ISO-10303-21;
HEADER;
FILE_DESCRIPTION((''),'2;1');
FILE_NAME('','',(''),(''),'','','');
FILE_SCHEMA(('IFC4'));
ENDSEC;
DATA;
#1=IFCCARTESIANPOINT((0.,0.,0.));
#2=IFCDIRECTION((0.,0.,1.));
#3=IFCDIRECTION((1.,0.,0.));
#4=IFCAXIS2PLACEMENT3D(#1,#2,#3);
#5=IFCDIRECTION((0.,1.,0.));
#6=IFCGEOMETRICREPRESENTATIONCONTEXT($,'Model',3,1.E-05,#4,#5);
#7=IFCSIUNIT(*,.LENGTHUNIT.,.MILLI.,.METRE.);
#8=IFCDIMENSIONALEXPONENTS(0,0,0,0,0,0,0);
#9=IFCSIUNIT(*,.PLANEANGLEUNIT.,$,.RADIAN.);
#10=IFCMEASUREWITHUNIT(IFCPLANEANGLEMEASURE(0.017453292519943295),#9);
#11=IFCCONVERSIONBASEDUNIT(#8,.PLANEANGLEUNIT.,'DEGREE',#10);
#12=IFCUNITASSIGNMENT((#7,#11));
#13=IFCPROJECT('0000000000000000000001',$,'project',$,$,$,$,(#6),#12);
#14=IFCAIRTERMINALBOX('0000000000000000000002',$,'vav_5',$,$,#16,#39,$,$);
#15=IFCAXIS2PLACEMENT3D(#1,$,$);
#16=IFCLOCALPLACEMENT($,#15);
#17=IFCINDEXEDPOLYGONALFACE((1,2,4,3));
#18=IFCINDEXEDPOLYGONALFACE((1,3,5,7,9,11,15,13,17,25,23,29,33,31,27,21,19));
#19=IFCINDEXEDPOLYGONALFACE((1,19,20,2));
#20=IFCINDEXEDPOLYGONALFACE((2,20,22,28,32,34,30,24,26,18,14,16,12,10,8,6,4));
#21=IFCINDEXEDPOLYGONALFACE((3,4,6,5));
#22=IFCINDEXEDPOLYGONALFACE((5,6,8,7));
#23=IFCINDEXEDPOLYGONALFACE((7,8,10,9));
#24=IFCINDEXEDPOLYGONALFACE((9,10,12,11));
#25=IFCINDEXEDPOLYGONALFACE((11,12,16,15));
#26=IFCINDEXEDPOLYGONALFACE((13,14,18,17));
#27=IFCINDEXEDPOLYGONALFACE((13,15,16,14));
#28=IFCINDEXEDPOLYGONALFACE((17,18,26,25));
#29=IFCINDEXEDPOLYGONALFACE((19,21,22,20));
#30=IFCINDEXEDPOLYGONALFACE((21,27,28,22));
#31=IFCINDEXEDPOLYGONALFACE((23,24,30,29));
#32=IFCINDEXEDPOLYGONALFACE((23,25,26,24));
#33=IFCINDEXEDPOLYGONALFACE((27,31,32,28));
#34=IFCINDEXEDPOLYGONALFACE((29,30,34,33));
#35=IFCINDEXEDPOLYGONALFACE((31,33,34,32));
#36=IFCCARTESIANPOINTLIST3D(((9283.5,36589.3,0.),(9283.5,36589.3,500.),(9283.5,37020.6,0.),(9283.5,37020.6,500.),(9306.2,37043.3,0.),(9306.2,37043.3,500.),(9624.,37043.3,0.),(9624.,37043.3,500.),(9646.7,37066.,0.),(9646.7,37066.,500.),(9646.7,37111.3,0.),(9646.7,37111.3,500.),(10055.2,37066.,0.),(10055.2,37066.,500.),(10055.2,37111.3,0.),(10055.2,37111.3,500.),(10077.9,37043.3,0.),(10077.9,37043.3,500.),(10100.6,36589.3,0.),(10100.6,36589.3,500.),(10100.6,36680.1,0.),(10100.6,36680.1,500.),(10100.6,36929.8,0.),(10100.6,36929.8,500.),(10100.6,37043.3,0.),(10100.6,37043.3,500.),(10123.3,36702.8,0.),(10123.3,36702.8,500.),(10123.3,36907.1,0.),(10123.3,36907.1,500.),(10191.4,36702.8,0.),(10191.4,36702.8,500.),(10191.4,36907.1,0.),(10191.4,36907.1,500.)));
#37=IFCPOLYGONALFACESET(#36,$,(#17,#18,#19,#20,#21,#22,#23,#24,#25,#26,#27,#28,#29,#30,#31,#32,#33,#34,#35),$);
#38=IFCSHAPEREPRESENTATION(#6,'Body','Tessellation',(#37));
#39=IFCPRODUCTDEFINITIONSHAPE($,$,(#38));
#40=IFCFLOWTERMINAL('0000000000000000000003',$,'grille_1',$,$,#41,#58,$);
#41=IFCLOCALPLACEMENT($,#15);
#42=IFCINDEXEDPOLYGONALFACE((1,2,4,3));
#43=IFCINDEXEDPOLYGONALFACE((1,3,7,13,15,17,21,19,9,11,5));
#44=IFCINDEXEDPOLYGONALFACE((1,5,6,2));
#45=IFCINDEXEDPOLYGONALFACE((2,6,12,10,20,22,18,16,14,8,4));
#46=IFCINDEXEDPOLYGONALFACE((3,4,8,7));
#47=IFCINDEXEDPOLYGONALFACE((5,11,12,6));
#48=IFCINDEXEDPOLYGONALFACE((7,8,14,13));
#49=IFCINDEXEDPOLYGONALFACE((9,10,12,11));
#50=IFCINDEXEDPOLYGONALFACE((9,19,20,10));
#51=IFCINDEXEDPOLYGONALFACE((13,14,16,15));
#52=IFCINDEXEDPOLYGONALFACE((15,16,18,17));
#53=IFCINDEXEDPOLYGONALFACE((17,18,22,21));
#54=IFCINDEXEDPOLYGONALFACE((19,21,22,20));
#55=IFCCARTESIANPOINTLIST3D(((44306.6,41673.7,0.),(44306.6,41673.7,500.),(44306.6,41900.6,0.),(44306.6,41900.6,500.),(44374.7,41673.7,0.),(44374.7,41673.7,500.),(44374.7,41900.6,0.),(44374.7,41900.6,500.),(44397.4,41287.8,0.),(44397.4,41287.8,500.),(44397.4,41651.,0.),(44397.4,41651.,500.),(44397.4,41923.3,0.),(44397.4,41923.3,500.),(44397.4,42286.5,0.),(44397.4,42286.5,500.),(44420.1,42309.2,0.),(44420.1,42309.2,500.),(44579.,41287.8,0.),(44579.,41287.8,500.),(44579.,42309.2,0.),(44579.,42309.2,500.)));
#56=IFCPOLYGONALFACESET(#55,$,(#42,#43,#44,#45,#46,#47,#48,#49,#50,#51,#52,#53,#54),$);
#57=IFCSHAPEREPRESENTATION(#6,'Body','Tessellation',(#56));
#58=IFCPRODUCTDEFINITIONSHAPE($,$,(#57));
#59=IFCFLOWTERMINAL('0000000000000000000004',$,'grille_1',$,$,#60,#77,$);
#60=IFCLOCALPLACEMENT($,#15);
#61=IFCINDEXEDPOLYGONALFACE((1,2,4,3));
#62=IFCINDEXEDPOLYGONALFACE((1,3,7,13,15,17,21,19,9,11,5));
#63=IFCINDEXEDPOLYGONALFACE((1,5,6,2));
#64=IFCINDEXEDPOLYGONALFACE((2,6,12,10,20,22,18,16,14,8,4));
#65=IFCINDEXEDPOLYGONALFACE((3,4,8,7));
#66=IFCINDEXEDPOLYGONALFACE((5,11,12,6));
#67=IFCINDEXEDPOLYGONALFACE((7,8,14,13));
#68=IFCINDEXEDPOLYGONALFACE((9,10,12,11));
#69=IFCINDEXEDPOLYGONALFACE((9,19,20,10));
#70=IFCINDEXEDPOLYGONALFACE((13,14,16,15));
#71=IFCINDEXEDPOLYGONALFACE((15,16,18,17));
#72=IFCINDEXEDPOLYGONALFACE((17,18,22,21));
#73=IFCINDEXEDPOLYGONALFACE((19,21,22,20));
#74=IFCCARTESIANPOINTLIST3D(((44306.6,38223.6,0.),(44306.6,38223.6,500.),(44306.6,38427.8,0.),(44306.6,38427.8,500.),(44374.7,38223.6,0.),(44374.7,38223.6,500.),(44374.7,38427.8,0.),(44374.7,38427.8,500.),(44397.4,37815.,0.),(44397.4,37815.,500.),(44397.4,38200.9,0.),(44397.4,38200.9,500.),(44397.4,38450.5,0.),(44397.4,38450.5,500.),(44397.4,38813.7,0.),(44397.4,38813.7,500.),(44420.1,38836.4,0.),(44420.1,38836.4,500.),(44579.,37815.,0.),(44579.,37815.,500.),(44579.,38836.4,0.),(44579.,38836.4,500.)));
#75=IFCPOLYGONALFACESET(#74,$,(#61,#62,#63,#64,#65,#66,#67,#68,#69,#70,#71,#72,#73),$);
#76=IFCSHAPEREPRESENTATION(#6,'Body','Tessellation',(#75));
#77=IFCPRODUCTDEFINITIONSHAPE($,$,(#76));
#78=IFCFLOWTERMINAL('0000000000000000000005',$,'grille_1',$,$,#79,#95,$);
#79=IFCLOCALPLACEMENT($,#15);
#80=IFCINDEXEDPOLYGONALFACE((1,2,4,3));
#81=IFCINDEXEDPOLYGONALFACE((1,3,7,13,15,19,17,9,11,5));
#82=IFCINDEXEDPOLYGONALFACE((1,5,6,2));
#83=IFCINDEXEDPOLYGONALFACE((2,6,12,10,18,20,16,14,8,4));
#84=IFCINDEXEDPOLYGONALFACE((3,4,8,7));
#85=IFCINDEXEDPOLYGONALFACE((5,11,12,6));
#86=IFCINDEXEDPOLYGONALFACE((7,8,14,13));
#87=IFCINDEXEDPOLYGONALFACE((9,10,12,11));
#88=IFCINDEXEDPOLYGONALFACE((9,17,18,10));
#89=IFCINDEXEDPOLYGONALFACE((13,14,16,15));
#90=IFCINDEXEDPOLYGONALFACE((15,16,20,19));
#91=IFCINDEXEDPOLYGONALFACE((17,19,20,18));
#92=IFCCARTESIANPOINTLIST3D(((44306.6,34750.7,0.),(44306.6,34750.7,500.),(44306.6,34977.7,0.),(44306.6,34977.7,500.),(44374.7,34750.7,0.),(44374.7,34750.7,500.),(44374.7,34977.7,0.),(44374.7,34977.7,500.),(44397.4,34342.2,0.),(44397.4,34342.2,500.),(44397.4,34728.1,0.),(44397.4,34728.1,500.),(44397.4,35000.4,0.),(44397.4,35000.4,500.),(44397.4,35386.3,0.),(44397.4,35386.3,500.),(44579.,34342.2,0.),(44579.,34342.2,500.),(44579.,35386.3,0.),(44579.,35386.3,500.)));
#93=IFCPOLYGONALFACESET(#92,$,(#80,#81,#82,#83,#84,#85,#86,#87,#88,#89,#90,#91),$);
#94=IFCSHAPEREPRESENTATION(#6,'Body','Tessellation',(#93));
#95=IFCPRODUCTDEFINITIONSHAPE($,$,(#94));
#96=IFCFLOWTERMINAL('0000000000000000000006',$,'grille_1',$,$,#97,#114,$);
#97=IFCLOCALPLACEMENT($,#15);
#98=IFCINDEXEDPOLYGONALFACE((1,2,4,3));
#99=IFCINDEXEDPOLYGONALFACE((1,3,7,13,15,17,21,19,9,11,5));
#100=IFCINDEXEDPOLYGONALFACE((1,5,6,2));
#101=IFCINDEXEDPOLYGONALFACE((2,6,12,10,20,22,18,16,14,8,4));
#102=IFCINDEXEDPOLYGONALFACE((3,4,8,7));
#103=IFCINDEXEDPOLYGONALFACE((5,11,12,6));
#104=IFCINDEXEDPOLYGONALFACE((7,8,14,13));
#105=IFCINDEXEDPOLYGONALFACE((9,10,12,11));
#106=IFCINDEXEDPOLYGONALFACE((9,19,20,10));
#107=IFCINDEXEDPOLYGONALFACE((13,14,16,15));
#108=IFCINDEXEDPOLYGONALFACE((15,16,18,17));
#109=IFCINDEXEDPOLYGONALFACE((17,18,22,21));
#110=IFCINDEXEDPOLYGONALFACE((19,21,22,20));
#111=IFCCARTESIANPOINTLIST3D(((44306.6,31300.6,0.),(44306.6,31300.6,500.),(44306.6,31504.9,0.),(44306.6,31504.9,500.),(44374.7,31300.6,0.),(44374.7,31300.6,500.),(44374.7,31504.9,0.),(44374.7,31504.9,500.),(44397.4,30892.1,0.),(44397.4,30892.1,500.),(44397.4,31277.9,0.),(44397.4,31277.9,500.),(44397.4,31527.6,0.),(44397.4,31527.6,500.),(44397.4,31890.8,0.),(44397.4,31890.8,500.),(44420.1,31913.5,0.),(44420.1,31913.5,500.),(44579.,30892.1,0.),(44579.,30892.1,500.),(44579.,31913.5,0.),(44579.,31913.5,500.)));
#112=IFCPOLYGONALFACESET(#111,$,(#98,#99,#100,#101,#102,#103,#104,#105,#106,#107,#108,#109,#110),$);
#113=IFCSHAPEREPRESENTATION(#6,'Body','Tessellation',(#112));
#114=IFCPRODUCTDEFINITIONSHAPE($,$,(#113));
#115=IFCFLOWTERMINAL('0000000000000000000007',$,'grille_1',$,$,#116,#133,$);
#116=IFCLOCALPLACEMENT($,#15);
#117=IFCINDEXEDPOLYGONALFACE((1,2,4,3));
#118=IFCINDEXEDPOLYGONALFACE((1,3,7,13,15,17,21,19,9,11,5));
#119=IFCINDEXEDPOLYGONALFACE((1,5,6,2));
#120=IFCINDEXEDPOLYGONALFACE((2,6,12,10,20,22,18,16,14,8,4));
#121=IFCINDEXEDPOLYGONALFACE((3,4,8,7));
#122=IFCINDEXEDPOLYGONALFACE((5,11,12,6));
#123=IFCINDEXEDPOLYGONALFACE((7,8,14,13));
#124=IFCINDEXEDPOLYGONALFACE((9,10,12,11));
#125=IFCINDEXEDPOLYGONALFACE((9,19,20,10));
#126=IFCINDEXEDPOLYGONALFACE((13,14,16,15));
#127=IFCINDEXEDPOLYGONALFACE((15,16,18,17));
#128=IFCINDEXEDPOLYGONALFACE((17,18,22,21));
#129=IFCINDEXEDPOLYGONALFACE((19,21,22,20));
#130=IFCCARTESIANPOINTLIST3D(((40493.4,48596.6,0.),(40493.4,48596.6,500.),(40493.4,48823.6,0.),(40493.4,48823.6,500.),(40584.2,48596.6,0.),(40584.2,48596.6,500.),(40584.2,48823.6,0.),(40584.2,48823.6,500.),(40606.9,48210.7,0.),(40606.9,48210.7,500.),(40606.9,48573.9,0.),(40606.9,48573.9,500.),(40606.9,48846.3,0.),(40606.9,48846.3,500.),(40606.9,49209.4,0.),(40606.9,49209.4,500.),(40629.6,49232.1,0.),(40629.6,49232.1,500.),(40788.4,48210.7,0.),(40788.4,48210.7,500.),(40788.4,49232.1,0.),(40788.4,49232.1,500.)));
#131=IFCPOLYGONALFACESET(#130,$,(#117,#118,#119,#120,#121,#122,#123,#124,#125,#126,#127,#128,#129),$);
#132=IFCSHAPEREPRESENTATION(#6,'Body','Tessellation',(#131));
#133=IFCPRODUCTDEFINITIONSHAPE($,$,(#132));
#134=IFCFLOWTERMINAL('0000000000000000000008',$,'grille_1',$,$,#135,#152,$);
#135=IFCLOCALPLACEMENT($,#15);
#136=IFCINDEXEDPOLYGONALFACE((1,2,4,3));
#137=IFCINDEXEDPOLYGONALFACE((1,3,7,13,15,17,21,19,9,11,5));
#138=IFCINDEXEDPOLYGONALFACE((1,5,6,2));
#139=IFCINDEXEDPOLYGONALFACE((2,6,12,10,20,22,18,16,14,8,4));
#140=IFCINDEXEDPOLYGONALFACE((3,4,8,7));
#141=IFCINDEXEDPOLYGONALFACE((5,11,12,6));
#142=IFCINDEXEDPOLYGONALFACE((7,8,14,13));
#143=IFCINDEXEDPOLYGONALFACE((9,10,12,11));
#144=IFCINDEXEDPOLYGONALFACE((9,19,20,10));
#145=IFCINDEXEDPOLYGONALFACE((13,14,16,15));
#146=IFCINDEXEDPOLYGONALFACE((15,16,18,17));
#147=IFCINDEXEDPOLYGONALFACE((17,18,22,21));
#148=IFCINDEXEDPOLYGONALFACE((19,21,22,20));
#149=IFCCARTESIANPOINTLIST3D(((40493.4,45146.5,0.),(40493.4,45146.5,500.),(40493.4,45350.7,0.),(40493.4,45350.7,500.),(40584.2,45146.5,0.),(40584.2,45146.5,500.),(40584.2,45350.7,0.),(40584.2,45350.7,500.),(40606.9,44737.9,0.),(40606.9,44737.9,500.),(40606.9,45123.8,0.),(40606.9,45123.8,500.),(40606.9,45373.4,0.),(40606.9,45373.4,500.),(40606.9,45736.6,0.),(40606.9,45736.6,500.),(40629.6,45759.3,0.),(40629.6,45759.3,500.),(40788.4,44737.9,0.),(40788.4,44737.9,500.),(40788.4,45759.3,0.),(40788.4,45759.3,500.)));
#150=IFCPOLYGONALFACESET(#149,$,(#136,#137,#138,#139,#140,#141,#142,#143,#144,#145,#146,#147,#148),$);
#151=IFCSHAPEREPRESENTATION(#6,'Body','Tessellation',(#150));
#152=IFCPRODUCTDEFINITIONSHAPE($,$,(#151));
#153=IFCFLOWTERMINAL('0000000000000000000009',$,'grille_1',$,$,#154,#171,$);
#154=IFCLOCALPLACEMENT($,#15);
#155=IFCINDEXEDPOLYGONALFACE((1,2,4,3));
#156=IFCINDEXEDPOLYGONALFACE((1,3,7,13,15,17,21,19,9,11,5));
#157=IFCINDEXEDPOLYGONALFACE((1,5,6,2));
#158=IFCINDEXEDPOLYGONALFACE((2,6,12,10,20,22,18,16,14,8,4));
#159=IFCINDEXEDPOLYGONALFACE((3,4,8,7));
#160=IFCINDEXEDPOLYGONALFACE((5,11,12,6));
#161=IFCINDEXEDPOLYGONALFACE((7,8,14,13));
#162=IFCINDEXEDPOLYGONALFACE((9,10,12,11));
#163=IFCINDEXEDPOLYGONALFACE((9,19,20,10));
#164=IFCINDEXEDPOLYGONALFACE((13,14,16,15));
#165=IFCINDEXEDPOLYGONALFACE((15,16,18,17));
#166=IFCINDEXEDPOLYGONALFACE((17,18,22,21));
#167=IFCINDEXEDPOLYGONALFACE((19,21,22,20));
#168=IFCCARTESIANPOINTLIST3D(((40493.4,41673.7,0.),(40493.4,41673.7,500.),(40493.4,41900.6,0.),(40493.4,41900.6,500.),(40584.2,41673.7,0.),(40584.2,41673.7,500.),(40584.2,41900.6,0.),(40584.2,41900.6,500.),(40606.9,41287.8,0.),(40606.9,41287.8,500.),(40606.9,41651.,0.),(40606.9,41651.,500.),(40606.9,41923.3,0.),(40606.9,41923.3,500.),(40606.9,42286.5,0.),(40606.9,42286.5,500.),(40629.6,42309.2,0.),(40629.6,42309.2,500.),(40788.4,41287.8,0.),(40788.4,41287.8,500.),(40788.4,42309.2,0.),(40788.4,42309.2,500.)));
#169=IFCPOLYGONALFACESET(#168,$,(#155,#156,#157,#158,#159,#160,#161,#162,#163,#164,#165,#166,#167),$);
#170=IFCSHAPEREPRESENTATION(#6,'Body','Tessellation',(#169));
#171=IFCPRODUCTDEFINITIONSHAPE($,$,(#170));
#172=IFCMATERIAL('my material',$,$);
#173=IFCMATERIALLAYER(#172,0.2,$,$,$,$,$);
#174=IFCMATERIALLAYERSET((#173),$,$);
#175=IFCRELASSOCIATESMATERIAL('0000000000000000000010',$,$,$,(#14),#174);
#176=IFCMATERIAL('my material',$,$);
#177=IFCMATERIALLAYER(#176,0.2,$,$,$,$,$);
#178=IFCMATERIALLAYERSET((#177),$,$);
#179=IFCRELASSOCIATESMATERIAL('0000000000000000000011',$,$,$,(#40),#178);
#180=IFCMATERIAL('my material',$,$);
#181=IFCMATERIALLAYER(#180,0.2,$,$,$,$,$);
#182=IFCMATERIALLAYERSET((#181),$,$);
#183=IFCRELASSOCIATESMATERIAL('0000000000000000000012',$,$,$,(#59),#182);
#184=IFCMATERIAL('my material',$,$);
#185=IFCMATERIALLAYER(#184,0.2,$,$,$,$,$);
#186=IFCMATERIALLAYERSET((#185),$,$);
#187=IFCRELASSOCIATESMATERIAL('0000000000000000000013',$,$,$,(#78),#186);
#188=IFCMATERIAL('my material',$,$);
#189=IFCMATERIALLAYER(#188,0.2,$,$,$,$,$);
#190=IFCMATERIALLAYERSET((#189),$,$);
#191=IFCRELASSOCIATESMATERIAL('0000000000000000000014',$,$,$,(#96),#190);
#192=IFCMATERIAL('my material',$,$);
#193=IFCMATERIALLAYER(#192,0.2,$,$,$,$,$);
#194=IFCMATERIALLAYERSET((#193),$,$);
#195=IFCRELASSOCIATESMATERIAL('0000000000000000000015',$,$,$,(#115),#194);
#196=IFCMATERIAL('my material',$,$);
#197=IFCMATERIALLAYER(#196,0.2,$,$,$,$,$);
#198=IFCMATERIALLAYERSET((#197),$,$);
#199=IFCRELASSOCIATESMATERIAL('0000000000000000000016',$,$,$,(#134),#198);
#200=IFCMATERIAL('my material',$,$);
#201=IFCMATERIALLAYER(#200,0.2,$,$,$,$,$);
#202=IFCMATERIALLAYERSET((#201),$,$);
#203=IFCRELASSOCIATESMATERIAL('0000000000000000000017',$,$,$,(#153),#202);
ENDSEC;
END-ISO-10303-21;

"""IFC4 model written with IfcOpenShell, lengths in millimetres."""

from ifc_helpers import new_model, entity, si_unit, converted_unit, direction, origin_with_axes, place, context, project, polyline, outline, extrude, material, layer, layer_set, layer_usage, element, save


model = new_model("IFC4")

# Units and contexts
model_context = context("Model", 3, precision=1e-05, world=origin_with_axes(), true_north=direction((0.0, 1.0, 0.0)))
ifc_project = project(units=[si_unit("LENGTHUNIT", "METRE", prefix="MILLI"), converted_unit("PLANEANGLEUNIT", "DEGREE", entity("IfcPlaneAngleMeasure", 0.017453292519943295), si_unit("PLANEANGLEUNIT", "RADIAN"), dimensions=[0, 0, 0, 0, 0, 0, 0])], contexts=[model_context])

# Air terminal box
ifc_material_1 = material(Name="my material")
ifc_layer_1 = layer(ifc_material_1, 0.2)
ifc_layer_set_1 = layer_set([ifc_layer_1])
ifc_layer_usage_1 = layer_usage(ifc_layer_set_1, "AXIS2", "POSITIVE", -0.1)
air_terminal_box_1_placement = place(None, origin_with_axes())
element("IfcAirTerminalBox", 1, at=air_terminal_box_1_placement, material=ifc_layer_usage_1, Name="vav_5", context=model_context, shape_type="SweptSolid", body=[
    extrude(outline(polyline([(9283.5, 36589.3), (10100.6, 36589.3), (10100.6, 36680.1), (10123.3, 36702.8), (10191.4, 36702.8), (10191.4, 36907.1), (10123.3, 36907.1), (10100.6, 36929.8), (10100.6, 37043.3), (10077.9, 37043.3), (10055.2, 37066.0), (10055.2, 37111.3), (9646.7, 37111.3), (9646.7, 37066.0), (9624.0, 37043.3), (9306.2, 37043.3), (9283.5, 37020.6), (9283.5, 36589.3)])), origin_with_axes(), (0.0, 0.0, 1.0), 500.0),
])

# Flow terminals
ifc_material_2 = material(Name="my material")
ifc_layer_2 = layer(ifc_material_2, 0.2)
ifc_layer_set_2 = layer_set([ifc_layer_2])
ifc_layer_usage_2 = layer_usage(ifc_layer_set_2, "AXIS2", "POSITIVE", -0.1)
flow_terminal_1_placement = place(None, origin_with_axes())
element("IfcFlowTerminal", 2, at=flow_terminal_1_placement, material=ifc_layer_usage_2, Name="grille_1", context=model_context, shape_type="SweptSolid", body=[
    extrude(outline(polyline([(44306.6, 41673.7), (44374.7, 41673.7), (44397.4, 41651.0), (44397.4, 41287.8), (44579.0, 41287.8), (44579.0, 42309.2), (44420.1, 42309.2), (44397.4, 42286.5), (44397.4, 41923.3), (44374.7, 41900.6), (44306.6, 41900.6), (44306.6, 41673.7)])), origin_with_axes(), (0.0, 0.0, 1.0), 500.0),
])
ifc_material_3 = material(Name="my material")
ifc_layer_3 = layer(ifc_material_3, 0.2)
ifc_layer_set_3 = layer_set([ifc_layer_3])
ifc_layer_usage_3 = layer_usage(ifc_layer_set_3, "AXIS2", "POSITIVE", -0.1)
flow_terminal_2_placement = place(None, origin_with_axes())
element("IfcFlowTerminal", 3, at=flow_terminal_2_placement, material=ifc_layer_usage_3, Name="grille_1", context=model_context, shape_type="SweptSolid", body=[
    extrude(outline(polyline([(44306.6, 38223.6), (44374.7, 38223.6), (44397.4, 38200.9), (44397.4, 37815.0), (44579.0, 37815.0), (44579.0, 38836.4), (44420.1, 38836.4), (44397.4, 38813.7), (44397.4, 38450.5), (44374.7, 38427.8), (44306.6, 38427.8), (44306.6, 38223.6)])), origin_with_axes(), (0.0, 0.0, 1.0), 500.0),
])
ifc_material_4 = material(Name="my material")
ifc_layer_4 = layer(ifc_material_4, 0.2)
ifc_layer_set_4 = layer_set([ifc_layer_4])
ifc_layer_usage_4 = layer_usage(ifc_layer_set_4, "AXIS2", "POSITIVE", -0.1)
flow_terminal_3_placement = place(None, origin_with_axes())
element("IfcFlowTerminal", 4, at=flow_terminal_3_placement, material=ifc_layer_usage_4, Name="grille_1", context=model_context, shape_type="SweptSolid", body=[
    extrude(outline(polyline([(44306.6, 34750.7), (44374.7, 34750.7), (44397.4, 34728.1), (44397.4, 34342.2), (44579.0, 34342.2), (44579.0, 35386.3), (44397.4, 35386.3), (44397.4, 35000.4), (44374.7, 34977.7), (44306.6, 34977.7), (44306.6, 34750.7)])), origin_with_axes(), (0.0, 0.0, 1.0), 500.0),
])
ifc_material_5 = material(Name="my material")
ifc_layer_5 = layer(ifc_material_5, 0.2)
ifc_layer_set_5 = layer_set([ifc_layer_5])
ifc_layer_usage_5 = layer_usage(ifc_layer_set_5, "AXIS2", "POSITIVE", -0.1)
flow_terminal_4_placement = place(None, origin_with_axes())
element("IfcFlowTerminal", 5, at=flow_terminal_4_placement, material=ifc_layer_usage_5, Name="grille_1", context=model_context, shape_type="SweptSolid", body=[
    extrude(outline(polyline([(44306.6, 31300.6), (44374.7, 31300.6), (44397.4, 31277.9), (44397.4, 30892.1), (44579.0, 30892.1), (44579.0, 31913.5), (44420.1, 31913.5), (44397.4, 31890.8), (44397.4, 31527.6), (44374.7, 31504.9), (44306.6, 31504.9), (44306.6, 31300.6)])), origin_with_axes(), (0.0, 0.0, 1.0), 500.0),
])
ifc_material_6 = material(Name="my material")
ifc_layer_6 = layer(ifc_material_6, 0.2)
ifc_layer_set_6 = layer_set([ifc_layer_6])
ifc_layer_usage_6 = layer_usage(ifc_layer_set_6, "AXIS2", "POSITIVE", -0.1)
flow_terminal_5_placement = place(None, origin_with_axes())
element("IfcFlowTerminal", 6, at=flow_terminal_5_placement, material=ifc_layer_usage_6, Name="grille_1", context=model_context, shape_type="SweptSolid", body=[
    extrude(outline(polyline([(40493.4, 48596.6), (40584.2, 48596.6), (40606.9, 48573.9), (40606.9, 48210.7), (40788.4, 48210.7), (40788.4, 49232.1), (40629.6, 49232.1), (40606.9, 49209.4), (40606.9, 48846.3), (40584.2, 48823.6), (40493.4, 48823.6), (40493.4, 48596.6)])), origin_with_axes(), (0.0, 0.0, 1.0), 500.0),
])
ifc_material_7 = material(Name="my material")
ifc_layer_7 = layer(ifc_material_7, 0.2)
ifc_layer_set_7 = layer_set([ifc_layer_7])
ifc_layer_usage_7 = layer_usage(ifc_layer_set_7, "AXIS2", "POSITIVE", -0.1)
flow_terminal_6_placement = place(None, origin_with_axes())
element("IfcFlowTerminal", 7, at=flow_terminal_6_placement, material=ifc_layer_usage_7, Name="grille_1", context=model_context, shape_type="SweptSolid", body=[
    extrude(outline(polyline([(40493.4, 45146.5), (40584.2, 45146.5), (40606.9, 45123.8), (40606.9, 44737.9), (40788.4, 44737.9), (40788.4, 45759.3), (40629.6, 45759.3), (40606.9, 45736.6), (40606.9, 45373.4), (40584.2, 45350.7), (40493.4, 45350.7), (40493.4, 45146.5)])), origin_with_axes(), (0.0, 0.0, 1.0), 500.0),
])
ifc_material_8 = material(Name="my material")
ifc_layer_8 = layer(ifc_material_8, 0.2)
ifc_layer_set_8 = layer_set([ifc_layer_8])
ifc_layer_usage_8 = layer_usage(ifc_layer_set_8, "AXIS2", "POSITIVE", -0.1)
flow_terminal_7_placement = place(None, origin_with_axes())
element("IfcFlowTerminal", 8, at=flow_terminal_7_placement, material=ifc_layer_usage_8, Name="grille_1", context=model_context, shape_type="SweptSolid", body=[
    extrude(outline(polyline([(40493.4, 41673.7), (40584.2, 41673.7), (40606.9, 41651.0), (40606.9, 41287.8), (40788.4, 41287.8), (40788.4, 42309.2), (40629.6, 42309.2), (40606.9, 42286.5), (40606.9, 41923.3), (40584.2, 41900.6), (40493.4, 41900.6), (40493.4, 41673.7)])), origin_with_axes(), (0.0, 0.0, 1.0), 500.0),
])

save(model, "model.ifc")
